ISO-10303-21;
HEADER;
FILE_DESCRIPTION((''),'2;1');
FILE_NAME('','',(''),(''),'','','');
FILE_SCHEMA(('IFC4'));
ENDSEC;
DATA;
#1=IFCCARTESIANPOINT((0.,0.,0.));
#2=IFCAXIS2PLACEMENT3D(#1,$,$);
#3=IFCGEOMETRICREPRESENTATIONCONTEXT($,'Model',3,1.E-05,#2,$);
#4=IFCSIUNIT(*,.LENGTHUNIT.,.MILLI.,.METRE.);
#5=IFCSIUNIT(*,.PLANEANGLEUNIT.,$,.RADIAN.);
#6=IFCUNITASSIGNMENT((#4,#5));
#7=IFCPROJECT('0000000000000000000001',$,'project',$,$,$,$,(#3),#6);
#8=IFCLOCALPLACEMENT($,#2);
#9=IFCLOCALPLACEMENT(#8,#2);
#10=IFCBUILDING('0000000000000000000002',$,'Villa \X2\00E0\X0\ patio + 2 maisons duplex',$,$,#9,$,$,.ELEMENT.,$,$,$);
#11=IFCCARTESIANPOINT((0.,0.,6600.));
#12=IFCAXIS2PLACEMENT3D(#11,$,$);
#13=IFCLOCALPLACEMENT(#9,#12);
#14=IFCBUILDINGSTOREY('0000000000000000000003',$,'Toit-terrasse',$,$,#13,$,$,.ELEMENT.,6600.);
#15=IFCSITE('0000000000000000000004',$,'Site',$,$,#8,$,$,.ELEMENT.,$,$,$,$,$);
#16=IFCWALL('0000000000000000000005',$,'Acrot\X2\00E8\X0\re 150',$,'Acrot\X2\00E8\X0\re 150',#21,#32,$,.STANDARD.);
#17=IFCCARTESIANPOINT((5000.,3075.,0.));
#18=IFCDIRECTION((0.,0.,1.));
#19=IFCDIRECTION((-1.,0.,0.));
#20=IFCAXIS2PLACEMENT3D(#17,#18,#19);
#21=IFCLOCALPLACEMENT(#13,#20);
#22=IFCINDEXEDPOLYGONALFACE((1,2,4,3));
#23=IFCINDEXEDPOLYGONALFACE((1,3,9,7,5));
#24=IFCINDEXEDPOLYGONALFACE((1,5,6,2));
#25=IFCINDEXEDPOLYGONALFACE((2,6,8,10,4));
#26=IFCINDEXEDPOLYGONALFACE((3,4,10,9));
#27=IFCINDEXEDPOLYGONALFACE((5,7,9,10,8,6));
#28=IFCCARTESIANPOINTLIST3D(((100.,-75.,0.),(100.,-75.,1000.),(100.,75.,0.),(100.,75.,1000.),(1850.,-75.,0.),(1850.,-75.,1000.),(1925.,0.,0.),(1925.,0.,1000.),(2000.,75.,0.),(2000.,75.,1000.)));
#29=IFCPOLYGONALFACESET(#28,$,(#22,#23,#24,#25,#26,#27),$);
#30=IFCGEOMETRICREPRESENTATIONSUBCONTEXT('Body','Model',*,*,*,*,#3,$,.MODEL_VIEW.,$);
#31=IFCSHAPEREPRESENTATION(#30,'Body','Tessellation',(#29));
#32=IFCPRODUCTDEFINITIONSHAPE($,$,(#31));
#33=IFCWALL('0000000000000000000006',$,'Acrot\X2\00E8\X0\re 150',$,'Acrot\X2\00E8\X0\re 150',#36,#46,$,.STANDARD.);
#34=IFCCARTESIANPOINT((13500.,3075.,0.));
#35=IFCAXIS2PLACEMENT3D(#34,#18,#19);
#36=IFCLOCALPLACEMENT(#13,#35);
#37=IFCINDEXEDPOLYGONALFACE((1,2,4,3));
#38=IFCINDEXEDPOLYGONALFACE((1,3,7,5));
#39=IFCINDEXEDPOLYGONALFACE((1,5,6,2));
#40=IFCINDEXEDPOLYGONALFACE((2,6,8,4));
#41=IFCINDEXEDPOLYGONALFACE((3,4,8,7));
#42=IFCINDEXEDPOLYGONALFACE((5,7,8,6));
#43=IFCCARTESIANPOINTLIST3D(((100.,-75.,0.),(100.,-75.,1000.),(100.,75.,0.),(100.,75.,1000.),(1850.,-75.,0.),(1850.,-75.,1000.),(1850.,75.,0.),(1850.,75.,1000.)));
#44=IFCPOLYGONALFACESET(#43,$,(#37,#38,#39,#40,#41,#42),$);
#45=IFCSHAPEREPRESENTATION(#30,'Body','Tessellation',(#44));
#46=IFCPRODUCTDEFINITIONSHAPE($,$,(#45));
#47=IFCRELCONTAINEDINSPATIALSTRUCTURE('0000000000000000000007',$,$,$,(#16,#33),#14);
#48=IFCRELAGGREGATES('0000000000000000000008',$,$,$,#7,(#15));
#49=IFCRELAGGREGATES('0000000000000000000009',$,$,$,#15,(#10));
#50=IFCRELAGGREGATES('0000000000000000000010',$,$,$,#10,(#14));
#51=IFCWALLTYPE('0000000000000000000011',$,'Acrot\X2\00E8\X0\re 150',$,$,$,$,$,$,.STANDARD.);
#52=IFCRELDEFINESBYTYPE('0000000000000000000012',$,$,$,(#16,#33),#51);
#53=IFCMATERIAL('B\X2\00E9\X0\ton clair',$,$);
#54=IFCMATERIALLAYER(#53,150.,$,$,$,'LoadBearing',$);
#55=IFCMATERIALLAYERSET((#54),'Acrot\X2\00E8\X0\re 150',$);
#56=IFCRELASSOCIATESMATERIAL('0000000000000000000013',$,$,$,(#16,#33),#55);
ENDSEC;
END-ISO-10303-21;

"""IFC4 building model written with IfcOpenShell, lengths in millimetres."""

from ifc_helpers import new_model, si_unit, frame, origin, place, context, subcontext, project, spatial, polyline, outline, extrude, material, layer, layer_set, layer_usage, type_object, element, save


model = new_model("IFC4")

# Units and contexts
model_context = context("Model", 3, precision=1e-05, world=origin())
body_context = subcontext(model_context, "Body", "Model", "MODEL_VIEW")
ifc_project = project(units=[si_unit("LENGTHUNIT", "METRE", prefix="MILLI"), si_unit("PLANEANGLEUNIT", "RADIAN")], contexts=[model_context])

# Site, building, storey
site_placement = place(None, origin())
site = spatial("IfcSite", under=ifc_project, at=site_placement, Name="Site", CompositionType="ELEMENT")
building_placement = place(site_placement, origin())
building = spatial("IfcBuilding", under=site, at=building_placement, Name="Villa à patio + 2 maisons duplex", CompositionType="ELEMENT")
storey_placement = place(building_placement, frame((0.0, 0.0, 6600.0)))
storey = spatial("IfcBuildingStorey", under=building, at=storey_placement, Name="Toit-terrasse", CompositionType="ELEMENT", Elevation=6600.0)

# Walls
ifc_material_1 = material(Name="Béton clair")
ifc_layer_1 = layer(ifc_material_1, 150.0, Category="LoadBearing")
ifc_layer_set_1 = layer_set([ifc_layer_1], Name="Acrotère 150")
ifc_layer_usage_1 = layer_usage(ifc_layer_set_1, "AXIS2", "NEGATIVE", 75.0)
wall_type_1 = type_object("IfcWallType", Name="Acrotère 150", PredefinedType="STANDARD")
wall_1_placement = place(storey_placement, frame((5000.0, 3075.0, 0.0), z_axis=(0.0, 0.0, 1.0), x_axis=(-1.0, 0.0, 0.0)))
element("IfcWall", 1, at=wall_1_placement, inside=storey, type_object=wall_type_1, material=ifc_layer_usage_1, Name="Acrotère 150", ObjectType="Acrotère 150", PredefinedType="STANDARD", context=body_context, shape_type="SweptSolid", body=[
    extrude(outline(polyline([(100.0, -75.0), (100.0, 75.0), (2000.0, 75.0), (1925.0, 0.0), (1850.0, -75.0), (100.0, -75.0)])), origin(), (0.0, 0.0, 1.0), 1000.0),
])
wall_2_placement = place(storey_placement, frame((13500.0, 3075.0, 0.0), z_axis=(0.0, 0.0, 1.0), x_axis=(-1.0, 0.0, 0.0)))
element("IfcWall", 2, at=wall_2_placement, inside=storey, type_object=wall_type_1, material=ifc_layer_usage_1, Name="Acrotère 150", ObjectType="Acrotère 150", PredefinedType="STANDARD", context=body_context, shape_type="SweptSolid", body=[
    extrude(outline(polyline([(100.0, -75.0), (100.0, 75.0), (1850.0, 75.0), (1850.0, -75.0), (100.0, -75.0)])), origin(), (0.0, 0.0, 1.0), 1000.0),
])

save(model, "model.ifc")
